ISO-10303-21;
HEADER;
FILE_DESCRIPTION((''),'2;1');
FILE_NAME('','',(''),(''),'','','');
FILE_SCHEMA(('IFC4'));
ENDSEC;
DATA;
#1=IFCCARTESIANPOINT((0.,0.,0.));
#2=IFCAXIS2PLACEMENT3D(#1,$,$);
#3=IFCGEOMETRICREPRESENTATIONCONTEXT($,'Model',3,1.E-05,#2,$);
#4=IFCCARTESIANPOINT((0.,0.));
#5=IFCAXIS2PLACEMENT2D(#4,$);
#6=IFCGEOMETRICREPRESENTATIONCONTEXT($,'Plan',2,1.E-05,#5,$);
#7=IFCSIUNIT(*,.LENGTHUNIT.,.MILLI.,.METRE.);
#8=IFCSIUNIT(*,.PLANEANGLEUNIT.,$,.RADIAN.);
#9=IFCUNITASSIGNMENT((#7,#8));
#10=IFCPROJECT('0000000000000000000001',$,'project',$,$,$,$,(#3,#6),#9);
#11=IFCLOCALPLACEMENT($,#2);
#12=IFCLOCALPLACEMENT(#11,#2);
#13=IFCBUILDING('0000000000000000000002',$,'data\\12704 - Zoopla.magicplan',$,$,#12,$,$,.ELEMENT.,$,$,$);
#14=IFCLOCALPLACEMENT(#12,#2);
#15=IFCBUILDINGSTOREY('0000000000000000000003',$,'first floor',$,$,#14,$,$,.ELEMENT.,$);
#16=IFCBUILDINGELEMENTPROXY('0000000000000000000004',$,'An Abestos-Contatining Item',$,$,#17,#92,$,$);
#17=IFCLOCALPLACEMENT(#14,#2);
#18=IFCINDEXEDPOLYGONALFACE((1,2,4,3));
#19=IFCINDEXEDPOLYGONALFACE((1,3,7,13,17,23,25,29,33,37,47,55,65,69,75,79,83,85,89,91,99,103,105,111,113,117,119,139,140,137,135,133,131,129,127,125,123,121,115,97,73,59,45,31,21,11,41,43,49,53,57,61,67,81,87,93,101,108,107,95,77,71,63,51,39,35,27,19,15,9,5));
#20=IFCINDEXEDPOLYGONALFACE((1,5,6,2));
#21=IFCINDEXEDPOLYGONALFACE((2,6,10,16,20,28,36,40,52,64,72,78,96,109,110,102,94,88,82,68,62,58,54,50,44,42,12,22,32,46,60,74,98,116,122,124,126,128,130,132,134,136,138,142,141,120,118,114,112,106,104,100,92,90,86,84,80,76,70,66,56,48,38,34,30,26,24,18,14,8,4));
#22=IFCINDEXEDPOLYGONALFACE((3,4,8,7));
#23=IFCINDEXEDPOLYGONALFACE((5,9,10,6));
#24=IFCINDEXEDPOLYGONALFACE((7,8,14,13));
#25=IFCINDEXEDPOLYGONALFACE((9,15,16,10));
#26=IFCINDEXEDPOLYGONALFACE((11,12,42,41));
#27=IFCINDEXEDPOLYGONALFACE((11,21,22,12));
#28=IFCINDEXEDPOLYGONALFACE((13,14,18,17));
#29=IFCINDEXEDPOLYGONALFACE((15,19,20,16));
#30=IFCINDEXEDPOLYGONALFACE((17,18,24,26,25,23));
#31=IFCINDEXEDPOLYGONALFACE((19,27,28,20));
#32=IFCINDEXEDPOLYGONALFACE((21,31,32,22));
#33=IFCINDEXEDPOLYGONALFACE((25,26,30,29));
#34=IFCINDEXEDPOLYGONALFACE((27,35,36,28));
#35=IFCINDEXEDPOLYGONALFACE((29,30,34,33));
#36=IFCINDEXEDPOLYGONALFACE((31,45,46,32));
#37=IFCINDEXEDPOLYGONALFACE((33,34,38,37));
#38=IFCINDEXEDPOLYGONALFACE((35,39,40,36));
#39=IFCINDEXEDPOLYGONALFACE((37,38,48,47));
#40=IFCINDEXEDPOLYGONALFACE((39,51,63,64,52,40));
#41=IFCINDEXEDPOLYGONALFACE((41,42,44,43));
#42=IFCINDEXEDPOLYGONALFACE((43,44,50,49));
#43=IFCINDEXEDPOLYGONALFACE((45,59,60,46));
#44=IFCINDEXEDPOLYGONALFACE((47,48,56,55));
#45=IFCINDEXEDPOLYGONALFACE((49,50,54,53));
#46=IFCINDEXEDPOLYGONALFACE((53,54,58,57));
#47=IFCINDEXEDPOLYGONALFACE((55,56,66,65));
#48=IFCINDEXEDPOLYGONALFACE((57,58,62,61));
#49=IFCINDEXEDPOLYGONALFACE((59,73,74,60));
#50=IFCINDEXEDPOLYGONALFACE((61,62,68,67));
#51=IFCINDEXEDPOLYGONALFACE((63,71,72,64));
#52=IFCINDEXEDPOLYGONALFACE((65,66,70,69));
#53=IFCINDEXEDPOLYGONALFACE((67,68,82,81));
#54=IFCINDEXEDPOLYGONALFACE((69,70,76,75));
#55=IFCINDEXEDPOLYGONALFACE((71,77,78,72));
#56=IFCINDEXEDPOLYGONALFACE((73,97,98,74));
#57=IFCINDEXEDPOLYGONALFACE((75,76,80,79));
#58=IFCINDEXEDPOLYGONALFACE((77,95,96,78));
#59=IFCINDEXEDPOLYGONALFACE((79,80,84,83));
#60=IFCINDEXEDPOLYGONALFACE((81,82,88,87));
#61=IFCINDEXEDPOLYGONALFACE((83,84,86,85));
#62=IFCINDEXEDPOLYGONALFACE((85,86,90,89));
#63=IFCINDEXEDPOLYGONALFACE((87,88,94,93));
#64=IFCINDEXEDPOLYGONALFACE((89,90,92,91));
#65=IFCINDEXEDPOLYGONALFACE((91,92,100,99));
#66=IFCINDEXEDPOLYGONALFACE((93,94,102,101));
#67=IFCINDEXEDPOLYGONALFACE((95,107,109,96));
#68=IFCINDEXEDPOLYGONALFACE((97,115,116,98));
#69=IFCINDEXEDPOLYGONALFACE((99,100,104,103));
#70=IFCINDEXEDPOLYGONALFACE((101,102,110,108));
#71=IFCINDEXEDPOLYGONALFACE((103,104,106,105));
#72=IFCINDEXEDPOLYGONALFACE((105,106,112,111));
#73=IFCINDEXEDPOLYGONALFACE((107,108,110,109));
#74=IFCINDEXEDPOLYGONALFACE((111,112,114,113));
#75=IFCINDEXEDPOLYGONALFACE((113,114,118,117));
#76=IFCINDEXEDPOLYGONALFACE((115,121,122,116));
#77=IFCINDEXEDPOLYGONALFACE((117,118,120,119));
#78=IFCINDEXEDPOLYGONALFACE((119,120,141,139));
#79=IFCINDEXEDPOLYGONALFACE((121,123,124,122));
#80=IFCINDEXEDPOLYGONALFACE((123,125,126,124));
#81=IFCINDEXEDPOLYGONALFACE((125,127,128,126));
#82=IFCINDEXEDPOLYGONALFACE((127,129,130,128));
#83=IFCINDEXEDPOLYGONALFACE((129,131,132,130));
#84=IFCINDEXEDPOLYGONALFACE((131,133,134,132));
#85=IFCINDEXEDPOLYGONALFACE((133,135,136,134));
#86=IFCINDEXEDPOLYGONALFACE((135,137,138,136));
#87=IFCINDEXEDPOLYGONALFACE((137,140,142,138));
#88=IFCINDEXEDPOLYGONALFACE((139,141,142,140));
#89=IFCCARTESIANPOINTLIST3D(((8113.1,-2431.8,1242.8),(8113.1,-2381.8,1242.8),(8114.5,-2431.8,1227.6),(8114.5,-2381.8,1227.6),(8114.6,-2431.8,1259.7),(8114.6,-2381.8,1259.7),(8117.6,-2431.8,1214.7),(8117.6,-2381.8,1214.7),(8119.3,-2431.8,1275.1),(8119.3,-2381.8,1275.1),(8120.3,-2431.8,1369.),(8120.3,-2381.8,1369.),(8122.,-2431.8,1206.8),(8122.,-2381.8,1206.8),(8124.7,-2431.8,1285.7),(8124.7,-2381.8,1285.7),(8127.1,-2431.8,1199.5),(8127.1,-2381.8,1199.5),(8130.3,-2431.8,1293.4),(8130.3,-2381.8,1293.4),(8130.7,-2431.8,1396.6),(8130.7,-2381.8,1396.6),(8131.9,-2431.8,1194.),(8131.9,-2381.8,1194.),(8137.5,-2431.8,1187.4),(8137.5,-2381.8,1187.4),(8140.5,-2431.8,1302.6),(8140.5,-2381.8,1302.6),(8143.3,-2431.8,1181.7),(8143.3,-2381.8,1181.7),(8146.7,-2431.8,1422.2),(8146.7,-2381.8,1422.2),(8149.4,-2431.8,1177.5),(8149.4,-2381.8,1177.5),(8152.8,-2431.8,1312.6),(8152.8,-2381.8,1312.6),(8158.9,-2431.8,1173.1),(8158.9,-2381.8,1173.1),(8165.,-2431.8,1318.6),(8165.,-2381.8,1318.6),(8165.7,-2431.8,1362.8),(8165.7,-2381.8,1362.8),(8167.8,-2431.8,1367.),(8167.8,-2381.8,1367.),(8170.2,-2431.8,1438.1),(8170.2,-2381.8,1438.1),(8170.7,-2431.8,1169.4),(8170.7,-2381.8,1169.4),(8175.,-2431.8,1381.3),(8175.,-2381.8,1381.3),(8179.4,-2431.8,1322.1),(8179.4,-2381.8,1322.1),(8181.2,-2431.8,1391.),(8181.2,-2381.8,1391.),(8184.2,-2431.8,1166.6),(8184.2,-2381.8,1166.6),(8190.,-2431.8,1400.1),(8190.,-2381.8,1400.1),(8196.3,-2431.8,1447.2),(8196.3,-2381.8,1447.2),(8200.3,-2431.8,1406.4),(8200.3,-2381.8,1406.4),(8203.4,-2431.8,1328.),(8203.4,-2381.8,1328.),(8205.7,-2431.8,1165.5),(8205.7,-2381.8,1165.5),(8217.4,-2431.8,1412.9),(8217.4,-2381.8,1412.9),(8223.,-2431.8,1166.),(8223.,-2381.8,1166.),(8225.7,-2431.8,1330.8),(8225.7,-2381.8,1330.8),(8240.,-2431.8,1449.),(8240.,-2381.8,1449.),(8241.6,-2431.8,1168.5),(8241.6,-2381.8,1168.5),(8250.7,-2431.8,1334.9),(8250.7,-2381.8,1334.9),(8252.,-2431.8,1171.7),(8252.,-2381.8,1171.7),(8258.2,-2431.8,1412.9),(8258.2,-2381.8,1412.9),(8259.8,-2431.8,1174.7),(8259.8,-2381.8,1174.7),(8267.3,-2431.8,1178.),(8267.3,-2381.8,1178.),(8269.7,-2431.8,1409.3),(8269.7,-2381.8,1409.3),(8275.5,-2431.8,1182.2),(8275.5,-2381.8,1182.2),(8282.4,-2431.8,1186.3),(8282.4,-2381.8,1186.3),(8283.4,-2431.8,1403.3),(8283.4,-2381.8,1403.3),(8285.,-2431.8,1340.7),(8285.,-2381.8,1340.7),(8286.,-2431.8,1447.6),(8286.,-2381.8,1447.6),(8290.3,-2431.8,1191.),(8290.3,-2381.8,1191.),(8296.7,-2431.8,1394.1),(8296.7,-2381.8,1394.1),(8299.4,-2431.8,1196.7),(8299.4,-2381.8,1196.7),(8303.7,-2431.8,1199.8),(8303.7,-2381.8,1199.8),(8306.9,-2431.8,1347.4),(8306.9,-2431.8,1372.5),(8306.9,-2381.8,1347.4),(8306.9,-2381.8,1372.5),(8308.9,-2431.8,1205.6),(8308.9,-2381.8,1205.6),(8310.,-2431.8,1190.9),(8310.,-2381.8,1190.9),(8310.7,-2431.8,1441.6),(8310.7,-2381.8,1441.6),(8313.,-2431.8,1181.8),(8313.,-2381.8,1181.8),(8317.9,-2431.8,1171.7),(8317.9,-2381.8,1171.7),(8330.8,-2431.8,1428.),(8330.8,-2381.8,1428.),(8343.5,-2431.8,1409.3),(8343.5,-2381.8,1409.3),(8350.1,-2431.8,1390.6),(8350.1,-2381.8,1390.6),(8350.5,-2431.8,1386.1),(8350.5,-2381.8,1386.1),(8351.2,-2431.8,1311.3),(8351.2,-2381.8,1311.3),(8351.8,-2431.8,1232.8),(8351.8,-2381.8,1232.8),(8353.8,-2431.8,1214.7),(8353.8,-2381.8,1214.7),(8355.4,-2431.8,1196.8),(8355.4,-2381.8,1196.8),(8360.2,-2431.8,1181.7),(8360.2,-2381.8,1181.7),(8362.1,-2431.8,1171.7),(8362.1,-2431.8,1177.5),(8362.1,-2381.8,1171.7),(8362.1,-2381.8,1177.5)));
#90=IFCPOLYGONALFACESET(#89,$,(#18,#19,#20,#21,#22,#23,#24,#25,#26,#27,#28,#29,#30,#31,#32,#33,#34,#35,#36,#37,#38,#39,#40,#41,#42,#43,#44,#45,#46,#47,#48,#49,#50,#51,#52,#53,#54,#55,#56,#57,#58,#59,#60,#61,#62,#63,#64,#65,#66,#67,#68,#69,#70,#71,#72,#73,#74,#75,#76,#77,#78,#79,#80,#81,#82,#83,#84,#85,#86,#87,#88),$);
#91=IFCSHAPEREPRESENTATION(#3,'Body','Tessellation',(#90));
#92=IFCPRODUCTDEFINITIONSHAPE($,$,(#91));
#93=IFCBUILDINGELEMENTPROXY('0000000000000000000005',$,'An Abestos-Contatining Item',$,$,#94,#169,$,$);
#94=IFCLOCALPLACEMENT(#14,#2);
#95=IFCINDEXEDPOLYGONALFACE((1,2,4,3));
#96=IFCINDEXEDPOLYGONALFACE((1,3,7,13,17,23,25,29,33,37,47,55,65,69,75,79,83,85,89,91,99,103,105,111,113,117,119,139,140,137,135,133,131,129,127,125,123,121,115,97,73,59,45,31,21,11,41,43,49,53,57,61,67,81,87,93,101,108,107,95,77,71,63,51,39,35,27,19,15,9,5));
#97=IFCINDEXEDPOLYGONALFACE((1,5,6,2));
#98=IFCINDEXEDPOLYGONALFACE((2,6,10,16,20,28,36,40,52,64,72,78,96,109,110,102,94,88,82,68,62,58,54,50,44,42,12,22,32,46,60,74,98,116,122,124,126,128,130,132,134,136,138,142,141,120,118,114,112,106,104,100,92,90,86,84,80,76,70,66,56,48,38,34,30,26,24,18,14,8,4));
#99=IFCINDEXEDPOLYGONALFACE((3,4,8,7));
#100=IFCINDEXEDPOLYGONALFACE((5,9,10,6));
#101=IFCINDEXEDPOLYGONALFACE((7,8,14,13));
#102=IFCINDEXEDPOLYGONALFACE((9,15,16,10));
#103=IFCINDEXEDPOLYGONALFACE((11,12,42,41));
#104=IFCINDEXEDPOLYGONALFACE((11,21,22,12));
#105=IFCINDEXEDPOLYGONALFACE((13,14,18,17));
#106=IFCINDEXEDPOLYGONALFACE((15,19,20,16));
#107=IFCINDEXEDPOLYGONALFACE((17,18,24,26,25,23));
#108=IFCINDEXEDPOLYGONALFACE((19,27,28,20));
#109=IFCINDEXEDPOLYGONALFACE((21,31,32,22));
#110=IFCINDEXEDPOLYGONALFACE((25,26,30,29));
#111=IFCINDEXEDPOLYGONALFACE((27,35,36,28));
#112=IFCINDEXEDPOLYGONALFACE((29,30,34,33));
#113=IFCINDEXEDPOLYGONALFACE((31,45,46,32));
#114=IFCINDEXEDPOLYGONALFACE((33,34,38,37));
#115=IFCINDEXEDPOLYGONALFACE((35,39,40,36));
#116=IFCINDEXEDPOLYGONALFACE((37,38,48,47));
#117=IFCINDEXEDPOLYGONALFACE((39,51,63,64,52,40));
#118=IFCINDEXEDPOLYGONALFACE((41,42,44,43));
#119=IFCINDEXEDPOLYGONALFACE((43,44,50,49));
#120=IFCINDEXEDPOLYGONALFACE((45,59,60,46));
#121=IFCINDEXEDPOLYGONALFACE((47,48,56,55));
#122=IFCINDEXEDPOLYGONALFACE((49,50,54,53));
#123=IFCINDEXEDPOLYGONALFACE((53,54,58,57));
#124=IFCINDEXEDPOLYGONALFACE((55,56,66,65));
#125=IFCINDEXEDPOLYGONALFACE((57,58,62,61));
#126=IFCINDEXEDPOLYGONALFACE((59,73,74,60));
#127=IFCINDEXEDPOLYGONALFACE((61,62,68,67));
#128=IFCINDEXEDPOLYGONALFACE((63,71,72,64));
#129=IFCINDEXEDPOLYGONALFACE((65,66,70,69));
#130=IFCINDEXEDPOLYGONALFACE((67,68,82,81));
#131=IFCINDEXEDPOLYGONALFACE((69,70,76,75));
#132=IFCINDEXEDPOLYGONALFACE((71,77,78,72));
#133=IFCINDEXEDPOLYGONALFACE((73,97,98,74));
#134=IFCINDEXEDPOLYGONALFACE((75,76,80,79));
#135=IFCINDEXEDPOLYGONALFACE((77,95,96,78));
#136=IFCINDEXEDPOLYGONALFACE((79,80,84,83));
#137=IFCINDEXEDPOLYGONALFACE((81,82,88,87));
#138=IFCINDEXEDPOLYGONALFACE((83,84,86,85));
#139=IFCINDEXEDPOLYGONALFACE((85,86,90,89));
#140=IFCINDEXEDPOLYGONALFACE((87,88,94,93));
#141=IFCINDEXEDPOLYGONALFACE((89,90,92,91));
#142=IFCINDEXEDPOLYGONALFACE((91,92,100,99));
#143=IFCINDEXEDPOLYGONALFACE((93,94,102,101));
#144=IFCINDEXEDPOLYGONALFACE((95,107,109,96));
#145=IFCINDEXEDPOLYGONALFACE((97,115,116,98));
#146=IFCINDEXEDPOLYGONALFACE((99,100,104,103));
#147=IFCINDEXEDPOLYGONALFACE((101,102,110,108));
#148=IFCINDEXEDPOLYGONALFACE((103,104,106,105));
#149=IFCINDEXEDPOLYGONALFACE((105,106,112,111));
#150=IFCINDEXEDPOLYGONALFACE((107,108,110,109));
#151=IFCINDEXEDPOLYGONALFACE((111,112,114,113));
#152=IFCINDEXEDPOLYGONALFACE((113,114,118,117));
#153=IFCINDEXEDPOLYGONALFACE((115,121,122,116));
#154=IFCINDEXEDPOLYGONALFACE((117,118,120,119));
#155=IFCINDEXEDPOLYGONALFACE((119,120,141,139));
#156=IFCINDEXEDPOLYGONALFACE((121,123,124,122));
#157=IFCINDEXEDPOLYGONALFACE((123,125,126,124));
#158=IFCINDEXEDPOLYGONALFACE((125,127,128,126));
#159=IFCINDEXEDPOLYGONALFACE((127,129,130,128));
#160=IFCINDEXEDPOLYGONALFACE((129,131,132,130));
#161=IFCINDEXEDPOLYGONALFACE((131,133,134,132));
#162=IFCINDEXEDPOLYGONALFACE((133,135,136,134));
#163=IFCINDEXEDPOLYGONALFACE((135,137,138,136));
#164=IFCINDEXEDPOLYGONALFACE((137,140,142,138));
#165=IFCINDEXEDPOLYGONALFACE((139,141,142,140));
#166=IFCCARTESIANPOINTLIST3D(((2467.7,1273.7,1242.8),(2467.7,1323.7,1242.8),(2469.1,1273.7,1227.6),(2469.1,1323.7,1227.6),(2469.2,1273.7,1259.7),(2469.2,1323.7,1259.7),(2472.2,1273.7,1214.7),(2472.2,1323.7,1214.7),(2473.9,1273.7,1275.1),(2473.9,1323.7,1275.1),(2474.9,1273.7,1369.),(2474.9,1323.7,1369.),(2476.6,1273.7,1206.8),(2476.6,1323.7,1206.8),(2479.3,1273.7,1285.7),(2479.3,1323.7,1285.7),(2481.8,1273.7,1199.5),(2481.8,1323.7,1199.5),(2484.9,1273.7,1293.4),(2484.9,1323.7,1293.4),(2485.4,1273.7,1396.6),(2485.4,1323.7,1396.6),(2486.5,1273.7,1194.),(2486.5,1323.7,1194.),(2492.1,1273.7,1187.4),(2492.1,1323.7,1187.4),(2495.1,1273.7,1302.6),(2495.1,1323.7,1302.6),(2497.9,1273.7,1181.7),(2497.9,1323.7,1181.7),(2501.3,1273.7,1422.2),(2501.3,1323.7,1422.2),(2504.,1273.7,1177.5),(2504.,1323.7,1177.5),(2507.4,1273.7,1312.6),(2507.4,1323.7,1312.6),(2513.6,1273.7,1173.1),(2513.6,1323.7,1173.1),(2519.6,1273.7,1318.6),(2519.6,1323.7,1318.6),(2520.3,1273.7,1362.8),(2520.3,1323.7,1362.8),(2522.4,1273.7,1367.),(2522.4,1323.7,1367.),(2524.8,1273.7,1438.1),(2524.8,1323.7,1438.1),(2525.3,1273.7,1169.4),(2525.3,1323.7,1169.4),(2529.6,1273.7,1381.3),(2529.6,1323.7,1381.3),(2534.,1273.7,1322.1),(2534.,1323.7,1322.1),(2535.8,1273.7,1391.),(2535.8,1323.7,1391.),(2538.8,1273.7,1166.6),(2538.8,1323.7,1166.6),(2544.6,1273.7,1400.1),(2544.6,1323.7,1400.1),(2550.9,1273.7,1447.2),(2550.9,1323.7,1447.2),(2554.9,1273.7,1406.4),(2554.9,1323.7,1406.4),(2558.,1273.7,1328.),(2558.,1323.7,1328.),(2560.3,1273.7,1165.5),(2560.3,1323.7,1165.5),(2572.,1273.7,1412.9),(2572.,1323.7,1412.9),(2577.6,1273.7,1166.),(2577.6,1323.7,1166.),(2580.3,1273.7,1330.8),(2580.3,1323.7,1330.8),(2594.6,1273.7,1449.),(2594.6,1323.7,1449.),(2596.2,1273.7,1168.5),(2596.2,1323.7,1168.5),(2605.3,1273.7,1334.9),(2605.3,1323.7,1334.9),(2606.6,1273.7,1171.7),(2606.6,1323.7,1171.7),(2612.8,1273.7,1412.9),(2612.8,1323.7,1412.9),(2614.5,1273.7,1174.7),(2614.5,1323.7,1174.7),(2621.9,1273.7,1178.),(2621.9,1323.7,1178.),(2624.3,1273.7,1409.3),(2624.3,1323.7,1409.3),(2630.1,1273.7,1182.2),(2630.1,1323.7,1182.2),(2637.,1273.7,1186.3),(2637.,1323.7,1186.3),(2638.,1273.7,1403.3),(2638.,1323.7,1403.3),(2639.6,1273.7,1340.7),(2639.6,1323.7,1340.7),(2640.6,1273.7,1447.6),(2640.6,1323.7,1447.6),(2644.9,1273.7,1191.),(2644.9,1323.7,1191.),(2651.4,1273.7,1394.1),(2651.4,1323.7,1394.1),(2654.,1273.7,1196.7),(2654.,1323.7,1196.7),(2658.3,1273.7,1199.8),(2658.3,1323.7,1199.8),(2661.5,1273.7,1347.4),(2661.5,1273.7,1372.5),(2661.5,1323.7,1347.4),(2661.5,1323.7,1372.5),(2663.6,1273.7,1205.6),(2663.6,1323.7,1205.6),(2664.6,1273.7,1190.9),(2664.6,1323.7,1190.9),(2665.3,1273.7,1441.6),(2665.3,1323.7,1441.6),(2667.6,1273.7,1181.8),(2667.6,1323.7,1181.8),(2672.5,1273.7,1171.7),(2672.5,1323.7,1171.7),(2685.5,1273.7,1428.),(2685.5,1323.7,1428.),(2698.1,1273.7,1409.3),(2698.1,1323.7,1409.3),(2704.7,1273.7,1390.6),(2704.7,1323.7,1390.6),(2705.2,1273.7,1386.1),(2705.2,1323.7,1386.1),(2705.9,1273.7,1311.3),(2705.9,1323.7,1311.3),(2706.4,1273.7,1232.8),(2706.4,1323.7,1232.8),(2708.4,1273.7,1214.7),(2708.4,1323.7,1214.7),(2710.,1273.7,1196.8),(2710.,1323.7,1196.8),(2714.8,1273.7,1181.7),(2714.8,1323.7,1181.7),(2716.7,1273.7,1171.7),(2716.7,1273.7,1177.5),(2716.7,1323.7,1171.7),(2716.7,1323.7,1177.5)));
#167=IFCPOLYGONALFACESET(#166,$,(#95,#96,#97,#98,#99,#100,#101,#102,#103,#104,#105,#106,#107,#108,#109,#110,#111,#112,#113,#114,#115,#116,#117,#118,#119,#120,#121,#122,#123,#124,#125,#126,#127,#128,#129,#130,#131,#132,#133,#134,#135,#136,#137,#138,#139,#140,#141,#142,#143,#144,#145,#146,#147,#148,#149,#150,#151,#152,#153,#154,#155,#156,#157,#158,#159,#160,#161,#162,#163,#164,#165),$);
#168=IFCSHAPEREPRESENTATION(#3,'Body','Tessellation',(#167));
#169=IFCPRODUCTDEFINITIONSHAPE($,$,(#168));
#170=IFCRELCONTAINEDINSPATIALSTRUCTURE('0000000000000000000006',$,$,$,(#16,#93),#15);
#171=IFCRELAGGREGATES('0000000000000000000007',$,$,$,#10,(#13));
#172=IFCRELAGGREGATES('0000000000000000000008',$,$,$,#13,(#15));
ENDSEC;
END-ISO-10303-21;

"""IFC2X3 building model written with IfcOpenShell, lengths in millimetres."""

from ifc_helpers import new_model, si_unit, frame, origin, origin_2d, place, context, project, spatial, polyline, outline, extrude, element, save


model = new_model("IFC2X3")

# Units and contexts
model_context = context("Model", 3, precision=1e-05, world=origin())
plan_context = context("Plan", 2, precision=1e-05, world=origin_2d())
ifc_project = project(units=[si_unit("LENGTHUNIT", "METRE", prefix="MILLI"), si_unit("PLANEANGLEUNIT", "RADIAN")], contexts=[model_context, plan_context])

# Building, storey
placement_1 = place(None, origin())
building_placement = place(placement_1, origin())
building = spatial("IfcBuilding", under=ifc_project, at=building_placement, Name="data\\12704 - Zoopla.magicplan", CompositionType="ELEMENT")
storey_placement = place(building_placement, origin())
storey = spatial("IfcBuildingStorey", under=building, at=storey_placement, Name="first floor", CompositionType="ELEMENT")

# Building element proxies
placement_2 = place(None, frame((3984.0, 1316.8, 0.0)))
proxy_1_placement = place(placement_2, frame((4128.1, -3698.6, 1165.0)))
element("IfcBuildingElementProxy", 1, at=proxy_1_placement, inside=storey, Name="An Abestos-Contatining Item", context=model_context, shape_type="SurfaceModel", body=[
    extrude(outline(polyline([(239.2, 0.0, 146.3), (239.7, 0.0, 67.8), (241.8, 0.0, 49.7), (243.3, 0.0, 31.9), (248.1, 0.0, 16.7), (250.0, 0.0, 12.5), (250.0, 0.0, 6.7), (205.8, 0.0, 6.7), (200.9, 0.0, 16.8), (197.9, 0.0, 25.9), (196.9, 0.0, 40.6), (191.6, 0.0, 34.8), (187.3, 0.0, 31.7), (178.2, 0.0, 26.0), (170.3, 0.0, 21.3), (163.4, 0.0, 17.2), (155.2, 0.0, 13.0), (147.8, 0.0, 9.7), (139.9, 0.0, 6.7), (129.5, 0.0, 3.5), (110.9, 0.0, 1.0), (93.6, 0.0, 0.5), (72.1, 0.0, 1.6), (58.6, 0.0, 4.4), (46.9, 0.0, 8.1), (37.3, 0.0, 12.5), (31.2, 0.0, 16.7), (25.4, 0.0, 22.4), (19.8, 0.0, 29.0), (15.1, 0.0, 34.5), (9.9, 0.0, 41.9), (5.5, 0.0, 49.7), (2.5, 0.0, 62.6), (1.0, 0.0, 77.8), (2.5, 0.0, 94.7), (7.2, 0.0, 110.1), (12.6, 0.0, 120.7), (18.2, 0.0, 128.4), (28.4, 0.0, 137.6), (40.7, 0.0, 147.6), (52.9, 0.0, 153.6), (67.3, 0.0, 157.1), (91.3, 0.0, 163.0), (113.7, 0.0, 165.8), (138.6, 0.0, 169.9), (172.9, 0.0, 175.7), (194.8, 0.0, 182.4), (194.8, 0.0, 207.5), (184.7, 0.0, 229.1), (171.3, 0.0, 238.3), (157.6, 0.0, 244.3), (146.2, 0.0, 247.9), (105.3, 0.0, 247.9), (88.3, 0.0, 241.4), (77.9, 0.0, 235.1), (69.1, 0.0, 226.0), (62.9, 0.0, 216.3), (55.7, 0.0, 202.0), (53.6, 0.0, 197.8), (8.2, 0.0, 204.0), (18.7, 0.0, 231.7), (34.6, 0.0, 257.2), (58.1, 0.0, 273.1), (84.2, 0.0, 282.2), (128.0, 0.0, 284.0), (173.9, 0.0, 282.6), (198.6, 0.0, 276.6), (218.8, 0.0, 263.1), (231.4, 0.0, 244.3), (238.0, 0.0, 225.6), (238.5, 0.0, 221.1)]), holes=[polyline([(193.0, 0.0, 144.2), (193.0, 0.0, 117.7), (190.5, 0.0, 97.8), (183.8, 0.0, 80.4), (174.2, 0.0, 64.5), (165.3, 0.0, 54.4), (152.5, 0.0, 47.3), (138.0, 0.0, 41.5), (124.6, 0.0, 37.8), (85.5, 0.0, 37.8), (75.0, 0.0, 41.4), (65.8, 0.0, 47.1), (57.8, 0.0, 55.4), (52.1, 0.0, 66.4), (49.5, 0.0, 74.4), (49.5, 0.0, 88.6), (55.3, 0.0, 100.7), (65.3, 0.0, 109.9), (81.0, 0.0, 119.8), (101.0, 0.0, 125.3), (119.9, 0.0, 128.5), (146.8, 0.0, 131.5), (165.0, 0.0, 134.9), (179.8, 0.0, 140.1), (193.0, 0.0, 144.2)])], kind="CURVE"), origin(), (0.0, -1.0, 0.0), 50.0),
])
placement_3 = place(None, frame((3984.0, 1316.8, 0.0)))
proxy_2_placement = place(placement_3, frame((-1517.3, 6.9, 1165.0)))
element("IfcBuildingElementProxy", 2, at=proxy_2_placement, inside=storey, Name="An Abestos-Contatining Item", context=model_context, shape_type="SurfaceModel", body=[
    extrude(outline(polyline([(239.2, 0.0, 146.3), (239.7, 0.0, 67.8), (241.8, 0.0, 49.7), (243.3, 0.0, 31.9), (248.1, 0.0, 16.7), (250.0, 0.0, 12.5), (250.0, 0.0, 6.7), (205.8, 0.0, 6.7), (200.9, 0.0, 16.8), (197.9, 0.0, 25.9), (196.9, 0.0, 40.6), (191.6, 0.0, 34.8), (187.3, 0.0, 31.7), (178.2, 0.0, 26.0), (170.3, 0.0, 21.3), (163.4, 0.0, 17.2), (155.2, 0.0, 13.0), (147.8, 0.0, 9.7), (139.9, 0.0, 6.7), (129.5, 0.0, 3.5), (110.9, 0.0, 1.0), (93.6, 0.0, 0.5), (72.1, 0.0, 1.6), (58.6, 0.0, 4.4), (46.9, 0.0, 8.1), (37.3, 0.0, 12.5), (31.2, 0.0, 16.7), (25.4, 0.0, 22.4), (19.8, 0.0, 29.0), (15.1, 0.0, 34.5), (9.9, 0.0, 41.9), (5.5, 0.0, 49.7), (2.5, 0.0, 62.6), (1.0, 0.0, 77.8), (2.5, 0.0, 94.7), (7.2, 0.0, 110.1), (12.6, 0.0, 120.7), (18.2, 0.0, 128.4), (28.4, 0.0, 137.6), (40.7, 0.0, 147.6), (52.9, 0.0, 153.6), (67.3, 0.0, 157.1), (91.3, 0.0, 163.0), (113.7, 0.0, 165.8), (138.6, 0.0, 169.9), (172.9, 0.0, 175.7), (194.8, 0.0, 182.4), (194.8, 0.0, 207.5), (184.7, 0.0, 229.1), (171.3, 0.0, 238.3), (157.6, 0.0, 244.3), (146.2, 0.0, 247.9), (105.3, 0.0, 247.9), (88.3, 0.0, 241.4), (77.9, 0.0, 235.1), (69.1, 0.0, 226.0), (62.9, 0.0, 216.3), (55.7, 0.0, 202.0), (53.6, 0.0, 197.8), (8.2, 0.0, 204.0), (18.7, 0.0, 231.7), (34.6, 0.0, 257.2), (58.1, 0.0, 273.1), (84.2, 0.0, 282.2), (128.0, 0.0, 284.0), (173.9, 0.0, 282.6), (198.6, 0.0, 276.6), (218.8, 0.0, 263.1), (231.4, 0.0, 244.3), (238.0, 0.0, 225.6), (238.5, 0.0, 221.1)]), holes=[polyline([(193.0, 0.0, 144.2), (193.0, 0.0, 117.7), (190.5, 0.0, 97.8), (183.8, 0.0, 80.4), (174.2, 0.0, 64.5), (165.3, 0.0, 54.4), (152.5, 0.0, 47.3), (138.0, 0.0, 41.5), (124.6, 0.0, 37.8), (85.5, 0.0, 37.8), (75.0, 0.0, 41.4), (65.8, 0.0, 47.1), (57.8, 0.0, 55.4), (52.1, 0.0, 66.4), (49.5, 0.0, 74.4), (49.5, 0.0, 88.6), (55.3, 0.0, 100.7), (65.3, 0.0, 109.9), (81.0, 0.0, 119.8), (101.0, 0.0, 125.3), (119.9, 0.0, 128.5), (146.8, 0.0, 131.5), (165.0, 0.0, 134.9), (179.8, 0.0, 140.1), (193.0, 0.0, 144.2)])], kind="CURVE"), origin(), (0.0, -1.0, 0.0), 50.0),
])

save(model, "model.ifc")
